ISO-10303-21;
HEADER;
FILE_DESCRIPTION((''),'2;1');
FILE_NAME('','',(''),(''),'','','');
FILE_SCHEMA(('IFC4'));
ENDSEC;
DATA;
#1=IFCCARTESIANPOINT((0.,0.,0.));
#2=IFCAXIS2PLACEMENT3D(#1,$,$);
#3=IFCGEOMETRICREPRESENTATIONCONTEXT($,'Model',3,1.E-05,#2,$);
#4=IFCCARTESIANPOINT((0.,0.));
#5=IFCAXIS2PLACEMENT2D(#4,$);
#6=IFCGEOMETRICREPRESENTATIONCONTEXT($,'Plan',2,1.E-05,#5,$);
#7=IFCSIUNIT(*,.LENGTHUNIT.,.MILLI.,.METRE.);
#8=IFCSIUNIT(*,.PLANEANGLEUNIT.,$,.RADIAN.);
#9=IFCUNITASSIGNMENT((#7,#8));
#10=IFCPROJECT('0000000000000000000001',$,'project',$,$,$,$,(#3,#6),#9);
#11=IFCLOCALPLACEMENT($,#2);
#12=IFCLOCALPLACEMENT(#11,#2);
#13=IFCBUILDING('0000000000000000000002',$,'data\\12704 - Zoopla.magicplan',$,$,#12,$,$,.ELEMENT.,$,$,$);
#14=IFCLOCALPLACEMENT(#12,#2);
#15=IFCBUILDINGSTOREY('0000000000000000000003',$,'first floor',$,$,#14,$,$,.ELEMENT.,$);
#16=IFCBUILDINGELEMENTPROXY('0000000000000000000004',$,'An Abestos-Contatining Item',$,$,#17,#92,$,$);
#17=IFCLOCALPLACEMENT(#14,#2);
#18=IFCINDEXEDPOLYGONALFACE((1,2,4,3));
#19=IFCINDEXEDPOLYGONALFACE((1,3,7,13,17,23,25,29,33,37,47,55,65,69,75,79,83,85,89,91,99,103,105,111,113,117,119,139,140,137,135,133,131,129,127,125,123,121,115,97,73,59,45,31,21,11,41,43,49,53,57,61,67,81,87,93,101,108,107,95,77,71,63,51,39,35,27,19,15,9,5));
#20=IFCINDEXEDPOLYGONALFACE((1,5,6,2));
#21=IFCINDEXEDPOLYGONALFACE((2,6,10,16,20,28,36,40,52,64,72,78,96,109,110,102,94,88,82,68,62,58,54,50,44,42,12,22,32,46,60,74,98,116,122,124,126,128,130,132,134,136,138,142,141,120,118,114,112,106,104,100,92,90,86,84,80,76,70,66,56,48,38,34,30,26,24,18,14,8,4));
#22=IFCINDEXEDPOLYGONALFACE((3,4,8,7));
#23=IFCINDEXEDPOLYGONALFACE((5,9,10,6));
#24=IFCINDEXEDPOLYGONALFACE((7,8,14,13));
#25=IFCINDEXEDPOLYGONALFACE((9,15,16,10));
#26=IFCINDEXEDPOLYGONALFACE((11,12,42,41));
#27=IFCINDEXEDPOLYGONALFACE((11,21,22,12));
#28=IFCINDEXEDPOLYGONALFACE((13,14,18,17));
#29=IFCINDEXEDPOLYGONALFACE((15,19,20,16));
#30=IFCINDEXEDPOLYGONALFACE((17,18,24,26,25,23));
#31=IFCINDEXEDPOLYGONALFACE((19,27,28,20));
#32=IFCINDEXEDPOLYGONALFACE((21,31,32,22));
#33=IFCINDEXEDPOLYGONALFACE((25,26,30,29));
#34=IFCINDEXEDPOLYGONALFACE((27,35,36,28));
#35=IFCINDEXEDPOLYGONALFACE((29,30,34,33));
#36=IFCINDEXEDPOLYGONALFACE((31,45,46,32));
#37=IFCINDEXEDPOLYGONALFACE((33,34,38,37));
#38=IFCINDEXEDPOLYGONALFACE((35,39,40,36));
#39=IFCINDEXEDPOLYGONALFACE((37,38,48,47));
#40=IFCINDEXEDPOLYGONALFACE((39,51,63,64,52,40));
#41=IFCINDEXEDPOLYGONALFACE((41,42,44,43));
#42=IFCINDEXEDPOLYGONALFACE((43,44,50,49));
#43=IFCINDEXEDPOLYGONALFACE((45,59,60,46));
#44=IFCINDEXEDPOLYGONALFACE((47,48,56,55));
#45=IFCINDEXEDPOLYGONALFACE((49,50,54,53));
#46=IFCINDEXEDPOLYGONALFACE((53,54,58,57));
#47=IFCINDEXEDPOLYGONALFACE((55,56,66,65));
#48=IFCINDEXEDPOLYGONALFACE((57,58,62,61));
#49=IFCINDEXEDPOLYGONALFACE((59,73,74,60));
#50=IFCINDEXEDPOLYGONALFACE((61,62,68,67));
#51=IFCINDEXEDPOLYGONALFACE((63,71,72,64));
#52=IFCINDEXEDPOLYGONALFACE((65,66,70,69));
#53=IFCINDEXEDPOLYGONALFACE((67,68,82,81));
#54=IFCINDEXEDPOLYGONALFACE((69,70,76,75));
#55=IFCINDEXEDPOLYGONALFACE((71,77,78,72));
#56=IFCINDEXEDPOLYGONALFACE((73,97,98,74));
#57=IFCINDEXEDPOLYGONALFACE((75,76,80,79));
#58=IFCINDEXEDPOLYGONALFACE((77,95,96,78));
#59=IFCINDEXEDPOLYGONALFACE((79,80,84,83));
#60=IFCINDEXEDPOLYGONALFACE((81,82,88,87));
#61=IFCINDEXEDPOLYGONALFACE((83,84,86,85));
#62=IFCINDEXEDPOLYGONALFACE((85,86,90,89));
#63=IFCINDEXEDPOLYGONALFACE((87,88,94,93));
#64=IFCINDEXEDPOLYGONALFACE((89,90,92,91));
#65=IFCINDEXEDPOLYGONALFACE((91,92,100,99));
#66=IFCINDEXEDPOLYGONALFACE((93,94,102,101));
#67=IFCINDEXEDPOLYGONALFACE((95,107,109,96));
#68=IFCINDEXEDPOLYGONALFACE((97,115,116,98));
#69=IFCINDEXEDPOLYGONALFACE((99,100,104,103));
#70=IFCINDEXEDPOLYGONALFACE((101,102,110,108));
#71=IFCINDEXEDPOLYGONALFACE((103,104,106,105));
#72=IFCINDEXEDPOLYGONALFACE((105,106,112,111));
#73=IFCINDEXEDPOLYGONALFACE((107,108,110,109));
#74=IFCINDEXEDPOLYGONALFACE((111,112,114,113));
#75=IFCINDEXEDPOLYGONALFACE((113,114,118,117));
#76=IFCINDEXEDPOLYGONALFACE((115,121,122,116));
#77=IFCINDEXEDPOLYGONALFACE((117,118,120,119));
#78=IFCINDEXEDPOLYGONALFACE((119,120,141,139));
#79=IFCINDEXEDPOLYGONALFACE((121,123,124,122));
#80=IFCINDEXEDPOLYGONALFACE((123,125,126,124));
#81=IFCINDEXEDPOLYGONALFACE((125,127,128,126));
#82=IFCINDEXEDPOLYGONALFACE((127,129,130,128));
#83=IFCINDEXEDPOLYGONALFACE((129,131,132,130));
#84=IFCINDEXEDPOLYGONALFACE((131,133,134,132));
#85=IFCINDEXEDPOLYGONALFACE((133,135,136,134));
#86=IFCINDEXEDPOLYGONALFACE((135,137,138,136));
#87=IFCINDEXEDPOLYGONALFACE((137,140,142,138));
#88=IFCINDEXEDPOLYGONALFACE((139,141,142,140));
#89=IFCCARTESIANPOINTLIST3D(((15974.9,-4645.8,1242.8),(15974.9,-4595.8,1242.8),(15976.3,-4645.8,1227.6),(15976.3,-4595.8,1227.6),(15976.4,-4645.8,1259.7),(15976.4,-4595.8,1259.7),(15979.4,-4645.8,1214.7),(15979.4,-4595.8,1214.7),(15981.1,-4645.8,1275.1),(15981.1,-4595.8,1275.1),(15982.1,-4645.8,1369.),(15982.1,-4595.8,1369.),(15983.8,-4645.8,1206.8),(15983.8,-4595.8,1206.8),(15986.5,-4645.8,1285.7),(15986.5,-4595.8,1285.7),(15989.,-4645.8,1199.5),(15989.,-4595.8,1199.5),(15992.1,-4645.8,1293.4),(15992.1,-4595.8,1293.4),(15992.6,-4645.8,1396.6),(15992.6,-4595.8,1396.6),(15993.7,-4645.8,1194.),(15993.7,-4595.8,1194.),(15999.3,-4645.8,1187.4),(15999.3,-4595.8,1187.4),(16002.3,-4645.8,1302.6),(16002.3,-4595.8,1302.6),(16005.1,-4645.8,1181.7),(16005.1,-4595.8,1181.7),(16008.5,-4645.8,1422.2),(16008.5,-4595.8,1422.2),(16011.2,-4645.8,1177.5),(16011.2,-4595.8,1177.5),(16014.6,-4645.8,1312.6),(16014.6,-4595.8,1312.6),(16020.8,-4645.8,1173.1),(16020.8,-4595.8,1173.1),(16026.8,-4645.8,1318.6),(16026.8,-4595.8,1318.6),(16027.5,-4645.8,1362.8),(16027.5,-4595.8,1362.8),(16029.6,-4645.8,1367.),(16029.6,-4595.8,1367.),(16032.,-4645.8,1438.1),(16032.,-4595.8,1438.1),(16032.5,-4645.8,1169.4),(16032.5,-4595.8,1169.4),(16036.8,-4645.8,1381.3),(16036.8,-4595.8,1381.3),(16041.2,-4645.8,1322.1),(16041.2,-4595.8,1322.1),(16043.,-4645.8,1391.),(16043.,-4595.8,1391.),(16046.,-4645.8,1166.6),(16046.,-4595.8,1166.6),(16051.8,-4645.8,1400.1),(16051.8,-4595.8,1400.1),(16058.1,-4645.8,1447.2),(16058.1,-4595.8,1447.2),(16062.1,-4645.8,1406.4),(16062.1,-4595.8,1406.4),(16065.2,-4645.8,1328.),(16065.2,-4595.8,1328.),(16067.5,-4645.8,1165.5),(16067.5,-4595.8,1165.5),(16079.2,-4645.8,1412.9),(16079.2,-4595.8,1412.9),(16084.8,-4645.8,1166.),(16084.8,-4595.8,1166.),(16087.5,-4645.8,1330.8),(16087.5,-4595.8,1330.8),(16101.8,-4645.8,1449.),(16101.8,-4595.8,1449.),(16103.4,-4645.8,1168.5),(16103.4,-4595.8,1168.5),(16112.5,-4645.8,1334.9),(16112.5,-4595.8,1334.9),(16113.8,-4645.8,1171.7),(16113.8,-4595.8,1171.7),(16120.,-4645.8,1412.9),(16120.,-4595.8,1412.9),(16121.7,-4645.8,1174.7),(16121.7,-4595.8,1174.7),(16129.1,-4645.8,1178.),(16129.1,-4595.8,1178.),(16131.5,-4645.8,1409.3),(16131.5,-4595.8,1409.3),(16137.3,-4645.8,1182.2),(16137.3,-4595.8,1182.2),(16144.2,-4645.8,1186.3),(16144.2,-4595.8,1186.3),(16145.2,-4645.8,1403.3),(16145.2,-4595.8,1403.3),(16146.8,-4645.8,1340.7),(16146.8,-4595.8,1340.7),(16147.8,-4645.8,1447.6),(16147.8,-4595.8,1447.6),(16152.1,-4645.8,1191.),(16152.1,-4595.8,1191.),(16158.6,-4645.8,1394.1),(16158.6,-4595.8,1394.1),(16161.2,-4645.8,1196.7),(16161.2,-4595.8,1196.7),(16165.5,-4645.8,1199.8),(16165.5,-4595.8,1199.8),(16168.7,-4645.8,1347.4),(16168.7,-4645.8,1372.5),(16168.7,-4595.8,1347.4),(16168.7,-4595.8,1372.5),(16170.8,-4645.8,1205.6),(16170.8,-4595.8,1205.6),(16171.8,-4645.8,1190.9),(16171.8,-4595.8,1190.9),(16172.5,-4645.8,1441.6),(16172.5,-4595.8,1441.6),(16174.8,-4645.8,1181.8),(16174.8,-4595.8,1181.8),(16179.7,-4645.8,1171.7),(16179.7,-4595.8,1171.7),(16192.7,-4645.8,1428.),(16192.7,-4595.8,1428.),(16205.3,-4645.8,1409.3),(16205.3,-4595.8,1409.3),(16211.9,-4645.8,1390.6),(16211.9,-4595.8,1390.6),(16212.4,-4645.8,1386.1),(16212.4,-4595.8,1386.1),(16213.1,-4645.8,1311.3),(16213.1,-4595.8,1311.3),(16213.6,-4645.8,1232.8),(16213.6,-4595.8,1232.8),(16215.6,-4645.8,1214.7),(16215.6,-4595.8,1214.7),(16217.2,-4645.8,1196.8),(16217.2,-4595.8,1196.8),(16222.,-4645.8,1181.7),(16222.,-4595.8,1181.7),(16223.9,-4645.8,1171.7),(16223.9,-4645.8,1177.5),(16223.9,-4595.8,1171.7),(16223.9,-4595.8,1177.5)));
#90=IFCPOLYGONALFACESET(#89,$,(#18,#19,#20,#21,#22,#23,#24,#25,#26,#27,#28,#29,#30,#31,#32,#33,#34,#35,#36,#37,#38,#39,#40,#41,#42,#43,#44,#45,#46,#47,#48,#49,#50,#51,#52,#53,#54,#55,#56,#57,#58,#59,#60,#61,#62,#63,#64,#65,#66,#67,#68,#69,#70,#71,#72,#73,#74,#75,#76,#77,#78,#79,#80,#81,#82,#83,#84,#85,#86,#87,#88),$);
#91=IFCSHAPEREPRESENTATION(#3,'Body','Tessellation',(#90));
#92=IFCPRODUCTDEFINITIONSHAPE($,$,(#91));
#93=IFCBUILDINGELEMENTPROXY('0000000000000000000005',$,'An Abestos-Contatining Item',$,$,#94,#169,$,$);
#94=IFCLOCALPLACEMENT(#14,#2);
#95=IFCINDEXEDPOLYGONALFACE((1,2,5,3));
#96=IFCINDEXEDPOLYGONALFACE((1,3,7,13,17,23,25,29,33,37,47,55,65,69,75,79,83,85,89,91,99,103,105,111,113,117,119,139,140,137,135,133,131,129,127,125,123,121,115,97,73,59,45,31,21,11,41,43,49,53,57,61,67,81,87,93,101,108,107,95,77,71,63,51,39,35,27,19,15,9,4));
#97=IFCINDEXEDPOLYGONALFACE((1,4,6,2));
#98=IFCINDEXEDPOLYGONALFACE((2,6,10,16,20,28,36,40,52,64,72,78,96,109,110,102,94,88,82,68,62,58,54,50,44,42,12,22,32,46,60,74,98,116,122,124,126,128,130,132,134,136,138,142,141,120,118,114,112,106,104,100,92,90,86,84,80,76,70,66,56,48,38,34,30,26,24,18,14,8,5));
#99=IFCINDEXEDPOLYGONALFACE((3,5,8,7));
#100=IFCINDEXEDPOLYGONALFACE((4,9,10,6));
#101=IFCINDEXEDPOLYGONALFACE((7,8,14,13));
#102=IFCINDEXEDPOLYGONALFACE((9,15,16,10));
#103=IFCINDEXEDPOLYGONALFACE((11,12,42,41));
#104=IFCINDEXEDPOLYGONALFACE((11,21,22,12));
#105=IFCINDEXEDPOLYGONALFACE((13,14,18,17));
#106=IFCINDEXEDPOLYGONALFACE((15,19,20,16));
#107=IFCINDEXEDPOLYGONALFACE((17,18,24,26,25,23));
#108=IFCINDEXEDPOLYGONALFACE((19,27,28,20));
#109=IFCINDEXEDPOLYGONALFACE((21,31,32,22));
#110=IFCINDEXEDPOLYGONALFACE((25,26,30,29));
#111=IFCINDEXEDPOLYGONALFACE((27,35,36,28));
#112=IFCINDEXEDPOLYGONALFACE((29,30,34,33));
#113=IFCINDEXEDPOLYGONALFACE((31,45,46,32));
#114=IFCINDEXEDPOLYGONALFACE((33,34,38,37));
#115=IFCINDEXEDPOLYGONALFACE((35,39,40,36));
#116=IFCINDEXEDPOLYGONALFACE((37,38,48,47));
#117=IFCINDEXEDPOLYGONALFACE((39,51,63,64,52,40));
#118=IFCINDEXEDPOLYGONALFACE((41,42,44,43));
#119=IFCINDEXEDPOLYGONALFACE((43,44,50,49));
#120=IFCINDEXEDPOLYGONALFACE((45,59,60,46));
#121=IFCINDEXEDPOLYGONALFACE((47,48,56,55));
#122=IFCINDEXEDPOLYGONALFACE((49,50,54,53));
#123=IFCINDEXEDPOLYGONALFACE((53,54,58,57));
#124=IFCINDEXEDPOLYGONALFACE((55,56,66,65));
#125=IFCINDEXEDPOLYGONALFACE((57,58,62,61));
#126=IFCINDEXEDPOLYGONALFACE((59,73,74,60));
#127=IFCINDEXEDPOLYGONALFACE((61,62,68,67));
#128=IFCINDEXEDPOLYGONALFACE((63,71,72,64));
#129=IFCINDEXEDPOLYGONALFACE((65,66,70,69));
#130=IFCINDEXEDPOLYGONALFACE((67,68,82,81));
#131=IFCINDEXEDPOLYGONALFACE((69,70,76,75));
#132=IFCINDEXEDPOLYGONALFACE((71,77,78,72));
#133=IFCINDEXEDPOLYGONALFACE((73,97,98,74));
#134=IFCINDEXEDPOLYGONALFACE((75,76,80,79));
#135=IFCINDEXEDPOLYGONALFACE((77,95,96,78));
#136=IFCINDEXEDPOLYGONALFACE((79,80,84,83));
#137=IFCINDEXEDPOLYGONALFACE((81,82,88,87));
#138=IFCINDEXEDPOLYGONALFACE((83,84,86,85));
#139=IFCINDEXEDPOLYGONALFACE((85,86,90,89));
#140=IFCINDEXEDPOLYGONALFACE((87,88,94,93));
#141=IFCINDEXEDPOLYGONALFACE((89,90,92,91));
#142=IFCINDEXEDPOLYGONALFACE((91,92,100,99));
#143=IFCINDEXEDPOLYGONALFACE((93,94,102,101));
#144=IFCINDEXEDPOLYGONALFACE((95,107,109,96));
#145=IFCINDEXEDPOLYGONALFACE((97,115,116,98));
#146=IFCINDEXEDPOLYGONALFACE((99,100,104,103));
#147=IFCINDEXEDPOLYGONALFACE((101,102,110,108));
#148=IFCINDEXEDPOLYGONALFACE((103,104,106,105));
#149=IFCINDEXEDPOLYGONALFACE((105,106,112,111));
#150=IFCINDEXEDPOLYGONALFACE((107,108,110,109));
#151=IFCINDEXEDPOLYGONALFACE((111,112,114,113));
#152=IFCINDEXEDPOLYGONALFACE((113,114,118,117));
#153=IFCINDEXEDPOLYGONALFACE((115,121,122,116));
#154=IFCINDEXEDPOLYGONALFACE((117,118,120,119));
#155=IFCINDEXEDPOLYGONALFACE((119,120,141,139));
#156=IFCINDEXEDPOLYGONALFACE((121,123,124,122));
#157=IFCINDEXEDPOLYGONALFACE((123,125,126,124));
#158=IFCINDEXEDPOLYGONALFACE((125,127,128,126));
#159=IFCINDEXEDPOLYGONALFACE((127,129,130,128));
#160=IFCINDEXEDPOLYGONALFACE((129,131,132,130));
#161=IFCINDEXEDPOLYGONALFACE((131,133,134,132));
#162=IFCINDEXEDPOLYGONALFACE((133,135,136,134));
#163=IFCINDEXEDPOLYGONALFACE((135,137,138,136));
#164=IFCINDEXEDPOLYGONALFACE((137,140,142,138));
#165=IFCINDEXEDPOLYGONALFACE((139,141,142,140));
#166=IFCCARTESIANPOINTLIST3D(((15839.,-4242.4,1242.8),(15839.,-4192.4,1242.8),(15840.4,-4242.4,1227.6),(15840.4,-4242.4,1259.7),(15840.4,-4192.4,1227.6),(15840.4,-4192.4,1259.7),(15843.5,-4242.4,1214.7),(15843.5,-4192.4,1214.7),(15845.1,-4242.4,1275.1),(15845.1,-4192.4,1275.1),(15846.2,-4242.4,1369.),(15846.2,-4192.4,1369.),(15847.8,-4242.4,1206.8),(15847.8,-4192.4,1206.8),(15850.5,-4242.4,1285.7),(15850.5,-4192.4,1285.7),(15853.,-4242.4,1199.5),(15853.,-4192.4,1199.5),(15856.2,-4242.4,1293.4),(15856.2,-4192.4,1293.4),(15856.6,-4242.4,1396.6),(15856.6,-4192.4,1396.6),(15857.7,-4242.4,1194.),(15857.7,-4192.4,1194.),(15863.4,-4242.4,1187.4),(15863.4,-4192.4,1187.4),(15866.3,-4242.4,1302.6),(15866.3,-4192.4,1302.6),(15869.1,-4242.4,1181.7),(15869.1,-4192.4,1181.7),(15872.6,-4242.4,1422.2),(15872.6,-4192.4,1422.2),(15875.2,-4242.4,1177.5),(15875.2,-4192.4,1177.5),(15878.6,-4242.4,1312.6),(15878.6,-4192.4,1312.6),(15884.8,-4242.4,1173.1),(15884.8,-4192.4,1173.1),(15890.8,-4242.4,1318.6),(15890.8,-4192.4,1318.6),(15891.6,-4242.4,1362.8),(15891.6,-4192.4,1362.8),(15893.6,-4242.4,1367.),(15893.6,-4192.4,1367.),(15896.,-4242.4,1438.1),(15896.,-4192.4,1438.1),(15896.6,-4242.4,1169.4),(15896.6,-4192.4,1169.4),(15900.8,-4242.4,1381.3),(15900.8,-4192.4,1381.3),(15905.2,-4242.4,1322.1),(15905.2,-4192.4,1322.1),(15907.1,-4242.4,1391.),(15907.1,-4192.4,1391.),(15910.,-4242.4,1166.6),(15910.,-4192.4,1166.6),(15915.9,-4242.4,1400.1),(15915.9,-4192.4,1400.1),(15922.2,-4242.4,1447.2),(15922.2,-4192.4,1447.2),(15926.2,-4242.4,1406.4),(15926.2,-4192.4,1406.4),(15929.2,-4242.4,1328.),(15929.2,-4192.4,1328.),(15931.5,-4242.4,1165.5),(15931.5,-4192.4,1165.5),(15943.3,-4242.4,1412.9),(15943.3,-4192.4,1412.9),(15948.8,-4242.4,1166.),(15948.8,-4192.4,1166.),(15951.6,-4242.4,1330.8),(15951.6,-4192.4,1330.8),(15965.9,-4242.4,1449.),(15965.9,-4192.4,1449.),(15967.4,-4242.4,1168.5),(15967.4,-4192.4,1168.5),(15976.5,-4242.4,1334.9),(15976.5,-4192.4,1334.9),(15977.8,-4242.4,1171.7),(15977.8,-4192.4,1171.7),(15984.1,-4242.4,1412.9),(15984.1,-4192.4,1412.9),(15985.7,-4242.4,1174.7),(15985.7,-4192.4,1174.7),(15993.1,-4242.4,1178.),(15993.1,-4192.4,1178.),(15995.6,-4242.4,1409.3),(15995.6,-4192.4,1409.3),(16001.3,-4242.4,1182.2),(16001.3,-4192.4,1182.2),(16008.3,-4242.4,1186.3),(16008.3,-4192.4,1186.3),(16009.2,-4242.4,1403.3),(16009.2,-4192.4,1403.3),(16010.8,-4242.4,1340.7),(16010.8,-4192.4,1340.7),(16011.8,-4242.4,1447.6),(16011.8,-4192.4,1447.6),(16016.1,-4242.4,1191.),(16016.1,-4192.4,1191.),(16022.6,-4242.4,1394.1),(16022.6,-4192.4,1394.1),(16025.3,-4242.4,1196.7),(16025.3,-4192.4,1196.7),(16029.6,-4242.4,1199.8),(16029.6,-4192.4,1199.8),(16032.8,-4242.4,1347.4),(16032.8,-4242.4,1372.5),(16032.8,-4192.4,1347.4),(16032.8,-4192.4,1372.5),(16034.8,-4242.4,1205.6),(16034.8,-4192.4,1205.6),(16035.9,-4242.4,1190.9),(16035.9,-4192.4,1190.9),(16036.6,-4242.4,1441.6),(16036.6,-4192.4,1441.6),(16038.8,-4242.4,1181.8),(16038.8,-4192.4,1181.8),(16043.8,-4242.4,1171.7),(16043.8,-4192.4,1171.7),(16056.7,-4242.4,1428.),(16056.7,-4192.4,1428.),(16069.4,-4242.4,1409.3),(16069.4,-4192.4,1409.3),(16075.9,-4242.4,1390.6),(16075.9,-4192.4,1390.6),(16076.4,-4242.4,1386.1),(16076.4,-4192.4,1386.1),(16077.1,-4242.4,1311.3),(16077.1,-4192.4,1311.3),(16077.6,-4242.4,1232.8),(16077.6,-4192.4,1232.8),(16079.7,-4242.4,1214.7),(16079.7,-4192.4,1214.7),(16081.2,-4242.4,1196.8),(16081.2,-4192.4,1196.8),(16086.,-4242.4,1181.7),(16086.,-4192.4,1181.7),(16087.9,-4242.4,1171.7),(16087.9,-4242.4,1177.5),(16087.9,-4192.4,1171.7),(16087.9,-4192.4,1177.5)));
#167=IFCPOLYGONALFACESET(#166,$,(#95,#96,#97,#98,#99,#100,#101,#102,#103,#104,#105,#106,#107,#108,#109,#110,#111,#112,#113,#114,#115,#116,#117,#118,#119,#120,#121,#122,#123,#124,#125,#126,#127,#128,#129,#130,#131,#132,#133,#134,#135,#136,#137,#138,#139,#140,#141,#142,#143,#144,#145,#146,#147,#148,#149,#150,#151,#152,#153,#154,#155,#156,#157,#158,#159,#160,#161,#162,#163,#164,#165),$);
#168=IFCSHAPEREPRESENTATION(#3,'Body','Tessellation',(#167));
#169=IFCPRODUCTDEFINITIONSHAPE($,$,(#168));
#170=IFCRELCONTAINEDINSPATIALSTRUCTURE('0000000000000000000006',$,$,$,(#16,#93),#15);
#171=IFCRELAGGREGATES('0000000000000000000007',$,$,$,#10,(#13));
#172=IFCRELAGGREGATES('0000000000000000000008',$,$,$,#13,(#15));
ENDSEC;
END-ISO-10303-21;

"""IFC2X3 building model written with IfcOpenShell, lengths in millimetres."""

from ifc_helpers import new_model, si_unit, frame, origin, origin_2d, place, context, project, spatial, polyline, outline, extrude, element, save


model = new_model("IFC2X3")

# Units and contexts
model_context = context("Model", 3, precision=1e-05, world=origin())
plan_context = context("Plan", 2, precision=1e-05, world=origin_2d())
ifc_project = project(units=[si_unit("LENGTHUNIT", "METRE", prefix="MILLI"), si_unit("PLANEANGLEUNIT", "RADIAN")], contexts=[model_context, plan_context])

# Building, storey
placement_1 = place(None, origin())
building_placement = place(placement_1, origin())
building = spatial("IfcBuilding", under=ifc_project, at=building_placement, Name="data\\12704 - Zoopla.magicplan", CompositionType="ELEMENT")
storey_placement = place(building_placement, origin())
storey = spatial("IfcBuildingStorey", under=building, at=storey_placement, Name="first floor", CompositionType="ELEMENT")

# Building element proxies
placement_2 = place(None, frame((17468.6, -3594.3, 0.0)))
proxy_1_placement = place(placement_2, frame((-1494.7, -1001.5, 1165.0)))
element("IfcBuildingElementProxy", 1, at=proxy_1_placement, inside=storey, Name="An Abestos-Contatining Item", context=model_context, shape_type="SurfaceModel", body=[
    extrude(outline(polyline([(239.2, 0.0, 146.3), (239.7, 0.0, 67.8), (241.8, 0.0, 49.7), (243.3, 0.0, 31.9), (248.1, 0.0, 16.7), (250.0, 0.0, 12.5), (250.0, 0.0, 6.7), (205.8, 0.0, 6.7), (200.9, 0.0, 16.8), (197.9, 0.0, 25.9), (196.9, 0.0, 40.6), (191.6, 0.0, 34.8), (187.3, 0.0, 31.7), (178.2, 0.0, 26.0), (170.3, 0.0, 21.3), (163.4, 0.0, 17.2), (155.2, 0.0, 13.0), (147.8, 0.0, 9.7), (139.9, 0.0, 6.7), (129.5, 0.0, 3.5), (110.9, 0.0, 1.0), (93.6, 0.0, 0.5), (72.1, 0.0, 1.6), (58.6, 0.0, 4.4), (46.9, 0.0, 8.1), (37.3, 0.0, 12.5), (31.2, 0.0, 16.7), (25.4, 0.0, 22.4), (19.8, 0.0, 29.0), (15.1, 0.0, 34.5), (9.9, 0.0, 41.9), (5.5, 0.0, 49.7), (2.5, 0.0, 62.6), (1.0, 0.0, 77.8), (2.5, 0.0, 94.7), (7.2, 0.0, 110.1), (12.6, 0.0, 120.7), (18.2, 0.0, 128.4), (28.4, 0.0, 137.6), (40.7, 0.0, 147.6), (52.9, 0.0, 153.6), (67.3, 0.0, 157.1), (91.3, 0.0, 163.0), (113.7, 0.0, 165.8), (138.6, 0.0, 169.9), (172.9, 0.0, 175.7), (194.8, 0.0, 182.4), (194.8, 0.0, 207.5), (184.7, 0.0, 229.1), (171.3, 0.0, 238.3), (157.6, 0.0, 244.3), (146.2, 0.0, 247.9), (105.3, 0.0, 247.9), (88.3, 0.0, 241.4), (77.9, 0.0, 235.1), (69.1, 0.0, 226.0), (62.9, 0.0, 216.3), (55.7, 0.0, 202.0), (53.6, 0.0, 197.8), (8.2, 0.0, 204.0), (18.7, 0.0, 231.7), (34.6, 0.0, 257.2), (58.1, 0.0, 273.1), (84.2, 0.0, 282.2), (128.0, 0.0, 284.0), (173.9, 0.0, 282.6), (198.6, 0.0, 276.6), (218.8, 0.0, 263.1), (231.4, 0.0, 244.3), (238.0, 0.0, 225.6), (238.5, 0.0, 221.1)]), holes=[polyline([(193.0, 0.0, 144.2), (193.0, 0.0, 117.7), (190.5, 0.0, 97.8), (183.8, 0.0, 80.4), (174.2, 0.0, 64.5), (165.3, 0.0, 54.4), (152.5, 0.0, 47.3), (138.0, 0.0, 41.5), (124.6, 0.0, 37.8), (85.5, 0.0, 37.8), (75.0, 0.0, 41.4), (65.8, 0.0, 47.1), (57.8, 0.0, 55.4), (52.1, 0.0, 66.4), (49.5, 0.0, 74.4), (49.5, 0.0, 88.6), (55.3, 0.0, 100.7), (65.3, 0.0, 109.9), (81.0, 0.0, 119.8), (101.0, 0.0, 125.3), (119.9, 0.0, 128.5), (146.8, 0.0, 131.5), (165.0, 0.0, 134.9), (179.8, 0.0, 140.1), (193.0, 0.0, 144.2)])], kind="CURVE"), origin(), (0.0, -1.0, 0.0), 50.0),
])
placement_3 = place(None, frame((17468.6, -3594.3, 0.0)))
proxy_2_placement = place(placement_3, frame((-1630.6, -598.1, 1165.0)))
element("IfcBuildingElementProxy", 2, at=proxy_2_placement, inside=storey, Name="An Abestos-Contatining Item", context=model_context, shape_type="SurfaceModel", body=[
    extrude(outline(polyline([(239.2, 0.0, 146.3), (239.7, 0.0, 67.8), (241.8, 0.0, 49.7), (243.3, 0.0, 31.9), (248.1, 0.0, 16.7), (250.0, 0.0, 12.5), (250.0, 0.0, 6.7), (205.8, 0.0, 6.7), (200.9, 0.0, 16.8), (197.9, 0.0, 25.9), (196.9, 0.0, 40.6), (191.6, 0.0, 34.8), (187.3, 0.0, 31.7), (178.2, 0.0, 26.0), (170.3, 0.0, 21.3), (163.4, 0.0, 17.2), (155.2, 0.0, 13.0), (147.8, 0.0, 9.7), (139.9, 0.0, 6.7), (129.5, 0.0, 3.5), (110.9, 0.0, 1.0), (93.6, 0.0, 0.5), (72.1, 0.0, 1.6), (58.6, 0.0, 4.4), (46.9, 0.0, 8.1), (37.3, 0.0, 12.5), (31.2, 0.0, 16.7), (25.4, 0.0, 22.4), (19.8, 0.0, 29.0), (15.1, 0.0, 34.5), (9.9, 0.0, 41.9), (5.5, 0.0, 49.7), (2.5, 0.0, 62.6), (1.0, 0.0, 77.8), (2.5, 0.0, 94.7), (7.2, 0.0, 110.1), (12.6, 0.0, 120.7), (18.2, 0.0, 128.4), (28.4, 0.0, 137.6), (40.7, 0.0, 147.6), (52.9, 0.0, 153.6), (67.3, 0.0, 157.1), (91.3, 0.0, 163.0), (113.7, 0.0, 165.8), (138.6, 0.0, 169.9), (172.9, 0.0, 175.7), (194.8, 0.0, 182.4), (194.8, 0.0, 207.5), (184.7, 0.0, 229.1), (171.3, 0.0, 238.3), (157.6, 0.0, 244.3), (146.2, 0.0, 247.9), (105.3, 0.0, 247.9), (88.3, 0.0, 241.4), (77.9, 0.0, 235.1), (69.1, 0.0, 226.0), (62.9, 0.0, 216.3), (55.7, 0.0, 202.0), (53.6, 0.0, 197.8), (8.2, 0.0, 204.0), (18.7, 0.0, 231.7), (34.6, 0.0, 257.2), (58.1, 0.0, 273.1), (84.2, 0.0, 282.2), (128.0, 0.0, 284.0), (173.9, 0.0, 282.6), (198.6, 0.0, 276.6), (218.8, 0.0, 263.1), (231.4, 0.0, 244.3), (238.0, 0.0, 225.6), (238.5, 0.0, 221.1)]), holes=[polyline([(193.0, 0.0, 144.2), (193.0, 0.0, 117.7), (190.5, 0.0, 97.8), (183.8, 0.0, 80.4), (174.2, 0.0, 64.5), (165.3, 0.0, 54.4), (152.5, 0.0, 47.3), (138.0, 0.0, 41.5), (124.6, 0.0, 37.8), (85.5, 0.0, 37.8), (75.0, 0.0, 41.4), (65.8, 0.0, 47.1), (57.8, 0.0, 55.4), (52.1, 0.0, 66.4), (49.5, 0.0, 74.4), (49.5, 0.0, 88.6), (55.3, 0.0, 100.7), (65.3, 0.0, 109.9), (81.0, 0.0, 119.8), (101.0, 0.0, 125.3), (119.9, 0.0, 128.5), (146.8, 0.0, 131.5), (165.0, 0.0, 134.9), (179.8, 0.0, 140.1), (193.0, 0.0, 144.2)])], kind="CURVE"), origin(), (0.0, -1.0, 0.0), 50.0),
])

save(model, "model.ifc")
